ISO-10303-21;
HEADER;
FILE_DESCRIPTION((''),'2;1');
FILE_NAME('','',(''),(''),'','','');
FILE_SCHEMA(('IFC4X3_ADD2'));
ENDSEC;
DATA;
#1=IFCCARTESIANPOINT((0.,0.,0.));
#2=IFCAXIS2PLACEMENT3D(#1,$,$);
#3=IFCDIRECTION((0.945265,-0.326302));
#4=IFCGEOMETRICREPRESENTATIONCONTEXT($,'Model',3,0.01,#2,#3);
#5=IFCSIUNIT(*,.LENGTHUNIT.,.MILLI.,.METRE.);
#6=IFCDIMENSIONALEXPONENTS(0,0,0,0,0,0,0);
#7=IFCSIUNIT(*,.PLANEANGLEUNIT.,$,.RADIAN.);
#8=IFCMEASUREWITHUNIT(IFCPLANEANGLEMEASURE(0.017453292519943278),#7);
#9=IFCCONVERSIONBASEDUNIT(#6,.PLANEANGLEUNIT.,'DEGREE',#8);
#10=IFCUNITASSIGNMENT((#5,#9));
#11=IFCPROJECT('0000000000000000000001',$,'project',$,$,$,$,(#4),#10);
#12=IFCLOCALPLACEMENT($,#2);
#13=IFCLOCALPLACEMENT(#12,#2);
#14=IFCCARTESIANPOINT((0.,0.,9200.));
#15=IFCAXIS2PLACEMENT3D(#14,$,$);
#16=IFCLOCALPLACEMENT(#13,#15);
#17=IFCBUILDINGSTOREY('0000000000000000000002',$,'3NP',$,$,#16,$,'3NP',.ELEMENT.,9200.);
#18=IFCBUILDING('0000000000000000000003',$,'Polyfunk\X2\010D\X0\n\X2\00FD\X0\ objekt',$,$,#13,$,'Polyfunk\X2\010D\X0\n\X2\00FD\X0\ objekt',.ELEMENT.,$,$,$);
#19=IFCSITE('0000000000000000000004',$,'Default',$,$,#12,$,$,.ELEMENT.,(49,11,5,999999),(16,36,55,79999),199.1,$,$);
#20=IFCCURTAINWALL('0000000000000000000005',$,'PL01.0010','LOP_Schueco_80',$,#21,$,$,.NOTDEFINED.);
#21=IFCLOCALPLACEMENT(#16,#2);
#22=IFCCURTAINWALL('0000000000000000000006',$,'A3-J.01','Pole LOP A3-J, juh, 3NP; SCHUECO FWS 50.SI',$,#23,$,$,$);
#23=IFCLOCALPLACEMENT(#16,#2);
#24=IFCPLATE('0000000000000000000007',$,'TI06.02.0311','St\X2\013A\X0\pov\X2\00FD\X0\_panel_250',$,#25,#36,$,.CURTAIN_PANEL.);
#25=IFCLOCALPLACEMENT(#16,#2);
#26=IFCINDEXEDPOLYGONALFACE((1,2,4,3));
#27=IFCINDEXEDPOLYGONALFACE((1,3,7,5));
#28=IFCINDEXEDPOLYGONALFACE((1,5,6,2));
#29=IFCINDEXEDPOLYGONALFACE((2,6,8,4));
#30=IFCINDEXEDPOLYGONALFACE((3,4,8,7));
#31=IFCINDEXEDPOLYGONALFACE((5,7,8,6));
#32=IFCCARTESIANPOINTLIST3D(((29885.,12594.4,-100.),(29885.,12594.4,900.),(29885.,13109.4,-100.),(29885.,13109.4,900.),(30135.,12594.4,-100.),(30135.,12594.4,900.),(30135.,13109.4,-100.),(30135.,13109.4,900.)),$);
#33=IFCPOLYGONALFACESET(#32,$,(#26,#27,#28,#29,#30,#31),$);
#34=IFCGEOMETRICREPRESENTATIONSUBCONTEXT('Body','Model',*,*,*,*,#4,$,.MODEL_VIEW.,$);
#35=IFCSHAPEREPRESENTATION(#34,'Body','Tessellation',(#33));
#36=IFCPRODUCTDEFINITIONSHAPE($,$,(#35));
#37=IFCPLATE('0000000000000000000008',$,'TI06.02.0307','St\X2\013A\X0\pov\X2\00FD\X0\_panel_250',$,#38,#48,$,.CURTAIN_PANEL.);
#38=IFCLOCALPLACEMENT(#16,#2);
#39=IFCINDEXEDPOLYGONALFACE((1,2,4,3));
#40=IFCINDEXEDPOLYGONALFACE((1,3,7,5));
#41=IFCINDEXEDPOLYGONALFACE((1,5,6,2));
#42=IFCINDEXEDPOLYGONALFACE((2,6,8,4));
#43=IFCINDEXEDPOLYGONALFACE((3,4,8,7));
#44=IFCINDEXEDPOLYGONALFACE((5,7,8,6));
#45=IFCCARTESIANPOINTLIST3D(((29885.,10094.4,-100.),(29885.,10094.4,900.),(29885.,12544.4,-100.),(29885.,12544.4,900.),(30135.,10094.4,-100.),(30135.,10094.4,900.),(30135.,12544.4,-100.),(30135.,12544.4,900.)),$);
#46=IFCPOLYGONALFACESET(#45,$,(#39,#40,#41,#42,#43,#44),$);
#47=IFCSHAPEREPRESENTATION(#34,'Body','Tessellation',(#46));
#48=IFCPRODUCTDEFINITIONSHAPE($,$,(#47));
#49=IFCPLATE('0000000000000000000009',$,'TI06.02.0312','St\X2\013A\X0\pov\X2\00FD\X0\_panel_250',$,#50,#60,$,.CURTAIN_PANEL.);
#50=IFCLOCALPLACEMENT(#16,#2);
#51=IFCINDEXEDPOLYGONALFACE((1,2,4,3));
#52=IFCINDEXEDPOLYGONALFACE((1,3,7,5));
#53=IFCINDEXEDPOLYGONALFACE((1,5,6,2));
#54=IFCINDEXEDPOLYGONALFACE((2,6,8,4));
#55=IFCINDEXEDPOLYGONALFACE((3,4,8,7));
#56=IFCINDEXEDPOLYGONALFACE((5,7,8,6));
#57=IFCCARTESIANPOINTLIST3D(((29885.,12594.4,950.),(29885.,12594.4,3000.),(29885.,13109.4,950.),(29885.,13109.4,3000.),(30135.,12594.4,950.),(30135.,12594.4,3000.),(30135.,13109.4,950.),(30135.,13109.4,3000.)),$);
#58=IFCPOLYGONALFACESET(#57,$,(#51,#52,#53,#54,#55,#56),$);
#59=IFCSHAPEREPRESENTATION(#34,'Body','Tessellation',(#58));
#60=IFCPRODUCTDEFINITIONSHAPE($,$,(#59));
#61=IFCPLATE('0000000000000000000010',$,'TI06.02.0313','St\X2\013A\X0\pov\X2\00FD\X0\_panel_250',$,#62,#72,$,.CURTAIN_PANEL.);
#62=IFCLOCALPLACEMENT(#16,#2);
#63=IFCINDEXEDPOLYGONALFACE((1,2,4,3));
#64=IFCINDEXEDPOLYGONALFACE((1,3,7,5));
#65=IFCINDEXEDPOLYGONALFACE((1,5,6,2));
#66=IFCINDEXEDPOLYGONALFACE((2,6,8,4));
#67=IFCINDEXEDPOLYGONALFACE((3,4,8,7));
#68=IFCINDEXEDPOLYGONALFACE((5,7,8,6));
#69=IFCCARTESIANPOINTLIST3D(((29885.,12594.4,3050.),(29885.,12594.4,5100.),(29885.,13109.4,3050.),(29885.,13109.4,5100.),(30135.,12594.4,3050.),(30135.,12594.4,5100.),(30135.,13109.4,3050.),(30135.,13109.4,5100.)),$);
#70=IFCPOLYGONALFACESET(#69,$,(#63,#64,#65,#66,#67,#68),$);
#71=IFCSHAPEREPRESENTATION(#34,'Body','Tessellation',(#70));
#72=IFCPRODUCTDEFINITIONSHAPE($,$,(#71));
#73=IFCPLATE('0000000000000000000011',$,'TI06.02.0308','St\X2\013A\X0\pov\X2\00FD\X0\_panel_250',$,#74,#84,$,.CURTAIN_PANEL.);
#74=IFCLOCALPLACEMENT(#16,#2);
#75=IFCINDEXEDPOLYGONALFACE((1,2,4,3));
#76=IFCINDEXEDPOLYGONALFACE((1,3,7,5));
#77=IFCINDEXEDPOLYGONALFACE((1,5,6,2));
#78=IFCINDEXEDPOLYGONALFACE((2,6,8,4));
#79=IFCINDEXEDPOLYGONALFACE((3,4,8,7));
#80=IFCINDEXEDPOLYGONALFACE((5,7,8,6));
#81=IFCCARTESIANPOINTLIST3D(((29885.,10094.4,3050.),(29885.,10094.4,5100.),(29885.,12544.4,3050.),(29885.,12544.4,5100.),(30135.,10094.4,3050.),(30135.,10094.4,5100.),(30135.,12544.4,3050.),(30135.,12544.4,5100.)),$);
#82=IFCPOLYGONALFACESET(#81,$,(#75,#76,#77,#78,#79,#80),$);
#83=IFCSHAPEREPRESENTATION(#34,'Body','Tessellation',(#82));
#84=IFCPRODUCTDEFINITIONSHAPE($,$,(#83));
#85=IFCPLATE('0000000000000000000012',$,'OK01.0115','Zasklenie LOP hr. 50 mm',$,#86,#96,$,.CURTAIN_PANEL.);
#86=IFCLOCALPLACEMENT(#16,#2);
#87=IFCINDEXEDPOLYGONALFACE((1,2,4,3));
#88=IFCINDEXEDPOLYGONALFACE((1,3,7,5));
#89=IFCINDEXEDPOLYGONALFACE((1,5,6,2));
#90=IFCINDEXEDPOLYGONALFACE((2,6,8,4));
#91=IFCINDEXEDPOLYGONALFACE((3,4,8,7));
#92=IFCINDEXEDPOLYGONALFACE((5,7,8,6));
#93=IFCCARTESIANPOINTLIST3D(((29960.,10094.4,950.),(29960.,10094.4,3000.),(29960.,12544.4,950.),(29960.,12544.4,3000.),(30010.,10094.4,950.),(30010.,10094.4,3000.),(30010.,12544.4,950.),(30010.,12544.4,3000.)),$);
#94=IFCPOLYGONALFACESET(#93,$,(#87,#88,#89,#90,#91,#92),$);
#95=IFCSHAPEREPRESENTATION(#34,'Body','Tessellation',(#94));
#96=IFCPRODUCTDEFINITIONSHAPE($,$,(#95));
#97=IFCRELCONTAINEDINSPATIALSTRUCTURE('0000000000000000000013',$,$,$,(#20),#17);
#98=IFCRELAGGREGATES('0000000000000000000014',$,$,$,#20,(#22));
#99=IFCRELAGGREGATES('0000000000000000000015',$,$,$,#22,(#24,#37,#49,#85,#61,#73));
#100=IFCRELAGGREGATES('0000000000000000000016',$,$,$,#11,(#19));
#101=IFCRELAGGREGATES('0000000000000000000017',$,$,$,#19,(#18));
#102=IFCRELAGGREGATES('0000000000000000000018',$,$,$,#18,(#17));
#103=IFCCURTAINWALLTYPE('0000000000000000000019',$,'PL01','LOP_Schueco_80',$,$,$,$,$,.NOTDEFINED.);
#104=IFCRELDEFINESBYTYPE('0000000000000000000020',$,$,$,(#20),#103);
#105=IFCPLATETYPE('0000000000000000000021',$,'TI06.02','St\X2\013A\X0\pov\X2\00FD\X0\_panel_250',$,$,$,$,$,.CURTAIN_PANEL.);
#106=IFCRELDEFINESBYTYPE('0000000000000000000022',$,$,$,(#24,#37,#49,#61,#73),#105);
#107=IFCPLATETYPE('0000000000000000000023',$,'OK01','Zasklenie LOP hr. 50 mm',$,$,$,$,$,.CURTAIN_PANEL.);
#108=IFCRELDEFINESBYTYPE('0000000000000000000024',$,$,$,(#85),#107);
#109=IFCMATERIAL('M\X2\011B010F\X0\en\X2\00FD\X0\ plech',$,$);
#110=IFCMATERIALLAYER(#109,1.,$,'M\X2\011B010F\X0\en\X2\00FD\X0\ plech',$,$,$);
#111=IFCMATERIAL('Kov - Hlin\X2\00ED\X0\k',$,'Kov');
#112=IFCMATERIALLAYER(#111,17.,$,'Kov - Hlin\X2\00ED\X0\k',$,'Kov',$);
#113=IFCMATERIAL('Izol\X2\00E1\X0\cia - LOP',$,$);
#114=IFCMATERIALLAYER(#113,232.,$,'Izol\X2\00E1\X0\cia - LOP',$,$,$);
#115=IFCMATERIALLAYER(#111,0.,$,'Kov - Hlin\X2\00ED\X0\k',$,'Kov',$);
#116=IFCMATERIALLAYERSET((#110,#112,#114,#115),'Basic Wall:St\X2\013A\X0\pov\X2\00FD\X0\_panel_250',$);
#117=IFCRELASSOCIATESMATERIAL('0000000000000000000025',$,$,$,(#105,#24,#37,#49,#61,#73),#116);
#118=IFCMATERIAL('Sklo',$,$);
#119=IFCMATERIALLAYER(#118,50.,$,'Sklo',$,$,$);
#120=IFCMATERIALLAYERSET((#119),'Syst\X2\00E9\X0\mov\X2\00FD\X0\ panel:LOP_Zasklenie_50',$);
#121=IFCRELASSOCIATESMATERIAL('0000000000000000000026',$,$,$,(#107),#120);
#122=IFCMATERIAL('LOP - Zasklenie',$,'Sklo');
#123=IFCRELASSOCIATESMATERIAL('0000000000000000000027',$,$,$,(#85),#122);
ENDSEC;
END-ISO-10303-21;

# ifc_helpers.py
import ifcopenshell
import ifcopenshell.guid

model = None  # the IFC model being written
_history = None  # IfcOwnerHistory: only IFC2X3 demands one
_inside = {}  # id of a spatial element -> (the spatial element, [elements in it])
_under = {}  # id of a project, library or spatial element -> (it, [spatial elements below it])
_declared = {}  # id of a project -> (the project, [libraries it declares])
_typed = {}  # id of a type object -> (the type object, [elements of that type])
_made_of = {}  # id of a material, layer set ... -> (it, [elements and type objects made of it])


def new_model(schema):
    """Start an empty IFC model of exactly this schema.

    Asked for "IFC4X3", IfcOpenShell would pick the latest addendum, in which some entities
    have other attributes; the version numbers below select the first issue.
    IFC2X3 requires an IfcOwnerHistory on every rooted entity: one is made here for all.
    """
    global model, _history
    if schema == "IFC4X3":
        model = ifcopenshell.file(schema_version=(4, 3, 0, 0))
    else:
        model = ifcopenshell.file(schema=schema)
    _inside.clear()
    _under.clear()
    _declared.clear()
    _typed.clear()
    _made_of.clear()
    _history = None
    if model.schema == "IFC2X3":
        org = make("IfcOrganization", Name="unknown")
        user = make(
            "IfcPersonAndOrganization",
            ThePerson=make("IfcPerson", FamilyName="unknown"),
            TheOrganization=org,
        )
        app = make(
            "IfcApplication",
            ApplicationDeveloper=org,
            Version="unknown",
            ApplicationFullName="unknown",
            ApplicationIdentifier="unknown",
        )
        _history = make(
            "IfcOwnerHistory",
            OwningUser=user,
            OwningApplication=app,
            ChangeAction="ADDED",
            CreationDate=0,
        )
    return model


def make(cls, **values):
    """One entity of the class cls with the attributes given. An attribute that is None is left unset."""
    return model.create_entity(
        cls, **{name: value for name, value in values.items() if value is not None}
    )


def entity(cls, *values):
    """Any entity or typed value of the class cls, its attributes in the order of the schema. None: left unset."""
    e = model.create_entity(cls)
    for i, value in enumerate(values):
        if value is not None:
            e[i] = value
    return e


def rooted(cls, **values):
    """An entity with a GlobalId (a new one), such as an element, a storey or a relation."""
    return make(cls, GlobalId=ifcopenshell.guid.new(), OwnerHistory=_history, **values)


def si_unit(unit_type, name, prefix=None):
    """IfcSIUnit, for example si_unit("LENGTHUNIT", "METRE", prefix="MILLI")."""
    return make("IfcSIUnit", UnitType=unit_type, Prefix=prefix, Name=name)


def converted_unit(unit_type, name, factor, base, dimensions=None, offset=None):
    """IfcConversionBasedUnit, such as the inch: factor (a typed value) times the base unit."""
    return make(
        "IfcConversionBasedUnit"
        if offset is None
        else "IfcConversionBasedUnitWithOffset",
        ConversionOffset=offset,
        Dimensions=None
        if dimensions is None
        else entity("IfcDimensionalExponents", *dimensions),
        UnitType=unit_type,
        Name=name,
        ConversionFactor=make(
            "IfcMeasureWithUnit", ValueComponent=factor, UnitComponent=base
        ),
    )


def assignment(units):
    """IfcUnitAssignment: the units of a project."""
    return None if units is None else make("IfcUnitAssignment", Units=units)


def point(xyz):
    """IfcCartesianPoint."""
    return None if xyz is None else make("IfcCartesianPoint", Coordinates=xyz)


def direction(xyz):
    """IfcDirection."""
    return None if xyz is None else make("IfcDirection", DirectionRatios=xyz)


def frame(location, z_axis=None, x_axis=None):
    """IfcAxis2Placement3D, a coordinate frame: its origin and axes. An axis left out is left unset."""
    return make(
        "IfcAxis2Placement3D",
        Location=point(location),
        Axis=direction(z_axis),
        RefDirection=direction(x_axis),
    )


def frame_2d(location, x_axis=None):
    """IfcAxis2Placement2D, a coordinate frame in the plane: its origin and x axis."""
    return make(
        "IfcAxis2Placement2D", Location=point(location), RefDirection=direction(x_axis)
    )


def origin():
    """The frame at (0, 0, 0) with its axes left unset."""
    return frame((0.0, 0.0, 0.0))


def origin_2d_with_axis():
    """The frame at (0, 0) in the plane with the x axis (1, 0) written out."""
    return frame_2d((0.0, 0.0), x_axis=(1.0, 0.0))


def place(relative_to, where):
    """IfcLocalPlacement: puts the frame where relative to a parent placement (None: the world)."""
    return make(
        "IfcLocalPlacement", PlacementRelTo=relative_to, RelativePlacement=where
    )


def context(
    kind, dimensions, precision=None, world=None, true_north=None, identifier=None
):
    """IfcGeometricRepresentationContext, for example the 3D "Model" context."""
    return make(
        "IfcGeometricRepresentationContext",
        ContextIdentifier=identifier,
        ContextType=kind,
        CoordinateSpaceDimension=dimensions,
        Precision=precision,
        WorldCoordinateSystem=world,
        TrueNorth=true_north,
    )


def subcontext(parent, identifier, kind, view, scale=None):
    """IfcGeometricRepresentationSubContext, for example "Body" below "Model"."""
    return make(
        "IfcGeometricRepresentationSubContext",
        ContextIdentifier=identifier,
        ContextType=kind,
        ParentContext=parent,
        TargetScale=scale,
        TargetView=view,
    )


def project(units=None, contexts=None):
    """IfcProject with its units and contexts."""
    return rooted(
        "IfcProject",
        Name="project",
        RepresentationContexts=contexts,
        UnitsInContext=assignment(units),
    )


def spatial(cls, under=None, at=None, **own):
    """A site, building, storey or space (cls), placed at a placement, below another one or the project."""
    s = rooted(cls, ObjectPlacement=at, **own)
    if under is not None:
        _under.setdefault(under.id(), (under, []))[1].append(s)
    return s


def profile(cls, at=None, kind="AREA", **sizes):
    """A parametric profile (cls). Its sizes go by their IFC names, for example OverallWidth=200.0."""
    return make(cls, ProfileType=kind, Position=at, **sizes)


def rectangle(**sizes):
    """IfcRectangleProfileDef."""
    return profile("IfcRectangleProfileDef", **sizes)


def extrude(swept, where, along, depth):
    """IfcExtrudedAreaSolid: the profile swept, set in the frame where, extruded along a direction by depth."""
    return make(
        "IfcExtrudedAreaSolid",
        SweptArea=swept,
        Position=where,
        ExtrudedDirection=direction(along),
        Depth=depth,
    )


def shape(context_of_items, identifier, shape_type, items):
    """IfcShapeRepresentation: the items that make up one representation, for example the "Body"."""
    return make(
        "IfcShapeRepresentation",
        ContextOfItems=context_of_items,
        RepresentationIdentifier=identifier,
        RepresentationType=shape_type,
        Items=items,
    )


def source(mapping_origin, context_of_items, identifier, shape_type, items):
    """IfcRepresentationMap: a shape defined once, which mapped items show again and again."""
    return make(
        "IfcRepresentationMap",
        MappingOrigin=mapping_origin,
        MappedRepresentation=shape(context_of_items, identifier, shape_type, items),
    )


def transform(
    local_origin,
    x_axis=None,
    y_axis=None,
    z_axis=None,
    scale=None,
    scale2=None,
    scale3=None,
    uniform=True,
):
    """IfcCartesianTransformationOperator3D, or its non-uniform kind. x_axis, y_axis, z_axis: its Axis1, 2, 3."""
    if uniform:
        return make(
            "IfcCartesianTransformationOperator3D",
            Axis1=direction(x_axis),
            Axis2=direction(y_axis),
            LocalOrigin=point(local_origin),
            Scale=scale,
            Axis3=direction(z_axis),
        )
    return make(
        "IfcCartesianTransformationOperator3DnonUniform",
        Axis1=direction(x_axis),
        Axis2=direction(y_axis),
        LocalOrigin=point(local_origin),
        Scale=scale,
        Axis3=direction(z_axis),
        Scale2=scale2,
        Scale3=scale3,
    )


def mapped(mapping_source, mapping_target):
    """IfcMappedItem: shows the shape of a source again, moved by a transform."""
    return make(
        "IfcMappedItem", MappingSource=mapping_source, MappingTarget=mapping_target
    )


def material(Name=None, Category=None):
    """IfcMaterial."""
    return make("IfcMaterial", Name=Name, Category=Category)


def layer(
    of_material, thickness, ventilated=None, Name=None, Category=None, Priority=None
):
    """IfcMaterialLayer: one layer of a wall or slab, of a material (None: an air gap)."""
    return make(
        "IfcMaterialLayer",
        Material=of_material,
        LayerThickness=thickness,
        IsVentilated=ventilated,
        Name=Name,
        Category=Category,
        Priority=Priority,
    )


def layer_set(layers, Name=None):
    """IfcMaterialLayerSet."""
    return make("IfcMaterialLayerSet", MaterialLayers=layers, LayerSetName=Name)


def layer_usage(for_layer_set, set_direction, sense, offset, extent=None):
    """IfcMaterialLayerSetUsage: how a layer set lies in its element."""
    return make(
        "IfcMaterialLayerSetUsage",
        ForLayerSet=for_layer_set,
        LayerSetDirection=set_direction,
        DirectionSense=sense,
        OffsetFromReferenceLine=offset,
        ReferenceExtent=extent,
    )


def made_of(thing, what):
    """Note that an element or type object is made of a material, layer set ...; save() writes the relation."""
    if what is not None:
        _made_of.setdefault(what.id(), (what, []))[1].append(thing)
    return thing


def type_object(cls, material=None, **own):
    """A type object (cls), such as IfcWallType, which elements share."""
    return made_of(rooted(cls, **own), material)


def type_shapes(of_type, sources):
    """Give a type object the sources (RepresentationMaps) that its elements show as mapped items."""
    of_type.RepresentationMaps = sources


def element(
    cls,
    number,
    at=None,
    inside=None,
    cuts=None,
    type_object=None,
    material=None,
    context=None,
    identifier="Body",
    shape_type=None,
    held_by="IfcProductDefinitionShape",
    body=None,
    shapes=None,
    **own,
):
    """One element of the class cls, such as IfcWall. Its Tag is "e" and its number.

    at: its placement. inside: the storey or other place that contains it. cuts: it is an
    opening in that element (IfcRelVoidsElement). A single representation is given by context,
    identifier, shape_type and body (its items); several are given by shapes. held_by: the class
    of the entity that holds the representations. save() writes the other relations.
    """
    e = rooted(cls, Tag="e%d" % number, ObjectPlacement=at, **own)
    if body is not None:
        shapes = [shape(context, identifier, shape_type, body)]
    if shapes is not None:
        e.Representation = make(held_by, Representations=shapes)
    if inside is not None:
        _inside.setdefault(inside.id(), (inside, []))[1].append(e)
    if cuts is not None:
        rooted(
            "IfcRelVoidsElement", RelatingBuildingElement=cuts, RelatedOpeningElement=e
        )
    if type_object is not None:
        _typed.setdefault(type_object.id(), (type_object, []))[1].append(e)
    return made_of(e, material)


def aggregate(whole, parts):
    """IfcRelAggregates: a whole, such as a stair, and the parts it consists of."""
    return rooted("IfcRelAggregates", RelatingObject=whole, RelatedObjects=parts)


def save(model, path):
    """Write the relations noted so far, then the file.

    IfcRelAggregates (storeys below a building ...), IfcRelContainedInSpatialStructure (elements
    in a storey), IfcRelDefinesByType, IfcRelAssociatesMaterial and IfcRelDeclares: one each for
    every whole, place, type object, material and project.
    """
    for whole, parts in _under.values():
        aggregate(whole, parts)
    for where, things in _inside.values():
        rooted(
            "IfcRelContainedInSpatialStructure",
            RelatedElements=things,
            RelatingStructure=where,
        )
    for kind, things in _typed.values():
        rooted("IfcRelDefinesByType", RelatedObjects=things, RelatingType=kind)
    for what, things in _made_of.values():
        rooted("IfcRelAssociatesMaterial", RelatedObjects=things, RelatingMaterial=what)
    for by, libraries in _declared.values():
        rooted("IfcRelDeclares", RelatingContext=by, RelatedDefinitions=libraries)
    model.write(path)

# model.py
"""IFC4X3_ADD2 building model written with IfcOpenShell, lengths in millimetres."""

from ifc_helpers import new_model, entity, si_unit, converted_unit, direction, frame, frame_2d, origin, origin_2d_with_axis, place, context, subcontext, project, spatial, rectangle, extrude, source, transform, mapped, material, layer, layer_set, layer_usage, type_object, type_shapes, element, aggregate, save


model = new_model("IFC4X3_ADD2")

# Units and contexts
model_context = context("Model", 3, precision=0.01, world=origin(), true_north=direction((0.945265, -0.326302)))
body_context = subcontext(model_context, "Body", "Model", "MODEL_VIEW")
ifc_project = project(units=[si_unit("LENGTHUNIT", "METRE", prefix="MILLI"), converted_unit("PLANEANGLEUNIT", "DEGREE", entity("IfcPlaneAngleMeasure", 0.017453292519943278), si_unit("PLANEANGLEUNIT", "RADIAN"), dimensions=[0, 0, 0, 0, 0, 0, 0])], contexts=[model_context])

# Site, building, storey
site_placement = place(None, origin())
site = spatial("IfcSite", under=ifc_project, at=site_placement, Name="Default", CompositionType="ELEMENT", RefLatitude=(49, 11, 5, 999999), RefLongitude=(16, 36, 55, 79999), RefElevation=199.1)
building_placement = place(site_placement, origin())
building = spatial("IfcBuilding", under=site, at=building_placement, Name="Polyfunkčný objekt", LongName="Polyfunkčný objekt", CompositionType="ELEMENT")
storey_placement = place(building_placement, frame((0.0, 0.0, 9200.0)))
storey = spatial("IfcBuildingStorey", under=building, at=storey_placement, Name="3NP", LongName="3NP", CompositionType="ELEMENT", Elevation=9200.0)

# Curtain walls
curtain_wall_type = type_object("IfcCurtainWallType", Name="PL01", Description="LOP_Schueco_80", PredefinedType="NOTDEFINED")
curtain_wall_1_placement = place(storey_placement, frame((0.0, 0.0, -9200.0)))
curtain_wall_1 = element("IfcCurtainWall", 1, at=curtain_wall_1_placement, inside=storey, type_object=curtain_wall_type, Name="PL01.0010", Description="LOP_Schueco_80", PredefinedType="NOTDEFINED")
curtain_wall_2 = element("IfcCurtainWall", 2, Name="A3-J.01", Description="Pole LOP A3-J, juh, 3NP; SCHUECO FWS 50.SI")
aggregate(curtain_wall_1, [curtain_wall_2])

# Plates
ifc_material_1 = material(Name="Měďený plech")
ifc_layer_1 = layer(ifc_material_1, 1.0, Name="Měďený plech")
ifc_material_2 = material(Name="Kov - Hliník", Category="Kov")
ifc_layer_2 = layer(ifc_material_2, 17.0, Name="Kov - Hliník", Category="Kov")
ifc_material_3 = material(Name="Izolácia - LOP")
ifc_layer_3 = layer(ifc_material_3, 232.0, Name="Izolácia - LOP")
ifc_layer_4 = layer(ifc_material_2, 0.0, Name="Kov - Hliník", Category="Kov")
ifc_layer_set_1 = layer_set([ifc_layer_1, ifc_layer_2, ifc_layer_3, ifc_layer_4], Name="Basic Wall:Stĺpový_panel_250")
ifc_layer_usage_1 = layer_usage(ifc_layer_set_1, "AXIS2", "POSITIVE", -125.0)
plate_type_1 = type_object("IfcPlateType", Name="TI06.02", Description="Stĺpový_panel_250", PredefinedType="CURTAIN_PANEL", material=ifc_layer_set_1)
plate_1_placement = place(storey_placement, frame((30010.0, 13109.4, -100.0), z_axis=(0.0, 0.0, 1.0), x_axis=(0.0, -1.0, 0.0)))
plate_1 = element("IfcPlate", 3, at=plate_1_placement, type_object=plate_type_1, material=ifc_layer_usage_1, Name="TI06.02.0311", Description="Stĺpový_panel_250", PredefinedType="CURTAIN_PANEL", context=body_context, shape_type="SweptSolid", body=[
    extrude(rectangle(XDim=250.0, YDim=515.0, at=frame_2d((0.0, 0.0), x_axis=(1.0, 0.0))), frame((257.5, 0.0, 0.0), z_axis=(0.0, 0.0, 1.0), x_axis=(0.0, 1.0, 0.0)), (0.0, 0.0, 1.0), 1000.0),
])
ifc_layer_usage_2 = layer_usage(ifc_layer_set_1, "AXIS2", "POSITIVE", -125.0)
plate_2_placement = place(storey_placement, frame((30010.0, 12544.4, -100.0), z_axis=(0.0, 0.0, 1.0), x_axis=(0.0, -1.0, 0.0)))
plate_2 = element("IfcPlate", 4, at=plate_2_placement, type_object=plate_type_1, material=ifc_layer_usage_2, Name="TI06.02.0307", Description="Stĺpový_panel_250", PredefinedType="CURTAIN_PANEL", context=body_context, shape_type="SweptSolid", body=[
    extrude(rectangle(XDim=250.0, YDim=2450.0, at=frame_2d((0.0, 0.0), x_axis=(1.0, 0.0))), frame((1225.0, 0.0, 0.0), z_axis=(0.0, 0.0, 1.0), x_axis=(0.0, 1.0, 0.0)), (0.0, 0.0, 1.0), 1000.0),
])
ifc_layer_usage_3 = layer_usage(ifc_layer_set_1, "AXIS2", "POSITIVE", -125.0)
plate_3_placement = place(storey_placement, frame((30010.0, 13109.4, 950.0), z_axis=(0.0, 0.0, 1.0), x_axis=(0.0, -1.0, 0.0)))
plate_3 = element("IfcPlate", 5, at=plate_3_placement, type_object=plate_type_1, material=ifc_layer_usage_3, Name="TI06.02.0312", Description="Stĺpový_panel_250", PredefinedType="CURTAIN_PANEL", context=body_context, shape_type="SweptSolid", body=[
    extrude(rectangle(XDim=250.0, YDim=515.0, at=frame_2d((0.0, 0.0), x_axis=(1.0, 0.0))), frame((257.5, 0.0, 0.0), z_axis=(0.0, 0.0, 1.0), x_axis=(0.0, 1.0, 0.0)), (0.0, 0.0, 1.0), 2050.0),
])
ifc_layer_usage_4 = layer_usage(ifc_layer_set_1, "AXIS2", "POSITIVE", -125.0)
plate_4_placement = place(storey_placement, frame((30010.0, 13109.4, 3050.0), z_axis=(0.0, 0.0, 1.0), x_axis=(0.0, -1.0, 0.0)))
plate_4 = element("IfcPlate", 6, at=plate_4_placement, type_object=plate_type_1, material=ifc_layer_usage_4, Name="TI06.02.0313", Description="Stĺpový_panel_250", PredefinedType="CURTAIN_PANEL", context=body_context, shape_type="SweptSolid", body=[
    extrude(rectangle(XDim=250.0, YDim=515.0, at=frame_2d((0.0, 0.0), x_axis=(1.0, 0.0))), frame((257.5, 0.0, 0.0), z_axis=(0.0, 0.0, 1.0), x_axis=(0.0, 1.0, 0.0)), (0.0, 0.0, 1.0), 2050.0),
])
ifc_layer_usage_5 = layer_usage(ifc_layer_set_1, "AXIS2", "POSITIVE", -125.0)
plate_5_placement = place(storey_placement, frame((30010.0, 12544.4, 3050.0), z_axis=(0.0, 0.0, 1.0), x_axis=(0.0, -1.0, 0.0)))
plate_5 = element("IfcPlate", 7, at=plate_5_placement, type_object=plate_type_1, material=ifc_layer_usage_5, Name="TI06.02.0308", Description="Stĺpový_panel_250", PredefinedType="CURTAIN_PANEL", context=body_context, shape_type="SweptSolid", body=[
    extrude(rectangle(XDim=250.0, YDim=2450.0, at=frame_2d((0.0, 0.0), x_axis=(1.0, 0.0))), frame((1225.0, 0.0, 0.0), z_axis=(0.0, 0.0, 1.0), x_axis=(0.0, 1.0, 0.0)), (0.0, 0.0, 1.0), 2050.0),
])
ifc_material_4 = material(Name="LOP - Zasklenie", Category="Sklo")
ifc_material_5 = material(Name="Sklo")
ifc_layer_5 = layer(ifc_material_5, 50.0, Name="Sklo")
ifc_layer_set_2 = layer_set([ifc_layer_5], Name="Systémový panel:LOP_Zasklenie_50")
plate_type_2 = type_object("IfcPlateType", Name="OK01", Description="Zasklenie LOP hr. 50 mm", PredefinedType="CURTAIN_PANEL", material=ifc_layer_set_2)
shared_shape_1 = source(origin(), body_context, "Body", "SweptSolid", [
    extrude(rectangle(XDim=50.0, YDim=2450.0, at=origin_2d_with_axis()), frame((0.0, -25.0, 0.0), z_axis=(0.0, 0.0, 1.0), x_axis=(0.0, 1.0, 0.0)), (0.0, 0.0, 1.0), 2050.0),
])
type_shapes(plate_type_2, [shared_shape_1])
plate_6_placement = place(curtain_wall_1_placement, frame((30010.0, 11319.4, 10150.0), z_axis=(0.0, 0.0, 1.0), x_axis=(0.0, -1.0, 0.0)))
plate_6 = element("IfcPlate", 8, at=plate_6_placement, type_object=plate_type_2, material=ifc_material_4, Name="OK01.0115", Description="Zasklenie LOP hr. 50 mm", PredefinedType="CURTAIN_PANEL", context=body_context, shape_type="MappedRepresentation", body=[
    mapped(shared_shape_1, transform((0.0, 0.0, 0.0), scale=1.0)),
])
aggregate(curtain_wall_2, [plate_1, plate_2, plate_3, plate_6, plate_4, plate_5])

save(model, "model.ifc")
